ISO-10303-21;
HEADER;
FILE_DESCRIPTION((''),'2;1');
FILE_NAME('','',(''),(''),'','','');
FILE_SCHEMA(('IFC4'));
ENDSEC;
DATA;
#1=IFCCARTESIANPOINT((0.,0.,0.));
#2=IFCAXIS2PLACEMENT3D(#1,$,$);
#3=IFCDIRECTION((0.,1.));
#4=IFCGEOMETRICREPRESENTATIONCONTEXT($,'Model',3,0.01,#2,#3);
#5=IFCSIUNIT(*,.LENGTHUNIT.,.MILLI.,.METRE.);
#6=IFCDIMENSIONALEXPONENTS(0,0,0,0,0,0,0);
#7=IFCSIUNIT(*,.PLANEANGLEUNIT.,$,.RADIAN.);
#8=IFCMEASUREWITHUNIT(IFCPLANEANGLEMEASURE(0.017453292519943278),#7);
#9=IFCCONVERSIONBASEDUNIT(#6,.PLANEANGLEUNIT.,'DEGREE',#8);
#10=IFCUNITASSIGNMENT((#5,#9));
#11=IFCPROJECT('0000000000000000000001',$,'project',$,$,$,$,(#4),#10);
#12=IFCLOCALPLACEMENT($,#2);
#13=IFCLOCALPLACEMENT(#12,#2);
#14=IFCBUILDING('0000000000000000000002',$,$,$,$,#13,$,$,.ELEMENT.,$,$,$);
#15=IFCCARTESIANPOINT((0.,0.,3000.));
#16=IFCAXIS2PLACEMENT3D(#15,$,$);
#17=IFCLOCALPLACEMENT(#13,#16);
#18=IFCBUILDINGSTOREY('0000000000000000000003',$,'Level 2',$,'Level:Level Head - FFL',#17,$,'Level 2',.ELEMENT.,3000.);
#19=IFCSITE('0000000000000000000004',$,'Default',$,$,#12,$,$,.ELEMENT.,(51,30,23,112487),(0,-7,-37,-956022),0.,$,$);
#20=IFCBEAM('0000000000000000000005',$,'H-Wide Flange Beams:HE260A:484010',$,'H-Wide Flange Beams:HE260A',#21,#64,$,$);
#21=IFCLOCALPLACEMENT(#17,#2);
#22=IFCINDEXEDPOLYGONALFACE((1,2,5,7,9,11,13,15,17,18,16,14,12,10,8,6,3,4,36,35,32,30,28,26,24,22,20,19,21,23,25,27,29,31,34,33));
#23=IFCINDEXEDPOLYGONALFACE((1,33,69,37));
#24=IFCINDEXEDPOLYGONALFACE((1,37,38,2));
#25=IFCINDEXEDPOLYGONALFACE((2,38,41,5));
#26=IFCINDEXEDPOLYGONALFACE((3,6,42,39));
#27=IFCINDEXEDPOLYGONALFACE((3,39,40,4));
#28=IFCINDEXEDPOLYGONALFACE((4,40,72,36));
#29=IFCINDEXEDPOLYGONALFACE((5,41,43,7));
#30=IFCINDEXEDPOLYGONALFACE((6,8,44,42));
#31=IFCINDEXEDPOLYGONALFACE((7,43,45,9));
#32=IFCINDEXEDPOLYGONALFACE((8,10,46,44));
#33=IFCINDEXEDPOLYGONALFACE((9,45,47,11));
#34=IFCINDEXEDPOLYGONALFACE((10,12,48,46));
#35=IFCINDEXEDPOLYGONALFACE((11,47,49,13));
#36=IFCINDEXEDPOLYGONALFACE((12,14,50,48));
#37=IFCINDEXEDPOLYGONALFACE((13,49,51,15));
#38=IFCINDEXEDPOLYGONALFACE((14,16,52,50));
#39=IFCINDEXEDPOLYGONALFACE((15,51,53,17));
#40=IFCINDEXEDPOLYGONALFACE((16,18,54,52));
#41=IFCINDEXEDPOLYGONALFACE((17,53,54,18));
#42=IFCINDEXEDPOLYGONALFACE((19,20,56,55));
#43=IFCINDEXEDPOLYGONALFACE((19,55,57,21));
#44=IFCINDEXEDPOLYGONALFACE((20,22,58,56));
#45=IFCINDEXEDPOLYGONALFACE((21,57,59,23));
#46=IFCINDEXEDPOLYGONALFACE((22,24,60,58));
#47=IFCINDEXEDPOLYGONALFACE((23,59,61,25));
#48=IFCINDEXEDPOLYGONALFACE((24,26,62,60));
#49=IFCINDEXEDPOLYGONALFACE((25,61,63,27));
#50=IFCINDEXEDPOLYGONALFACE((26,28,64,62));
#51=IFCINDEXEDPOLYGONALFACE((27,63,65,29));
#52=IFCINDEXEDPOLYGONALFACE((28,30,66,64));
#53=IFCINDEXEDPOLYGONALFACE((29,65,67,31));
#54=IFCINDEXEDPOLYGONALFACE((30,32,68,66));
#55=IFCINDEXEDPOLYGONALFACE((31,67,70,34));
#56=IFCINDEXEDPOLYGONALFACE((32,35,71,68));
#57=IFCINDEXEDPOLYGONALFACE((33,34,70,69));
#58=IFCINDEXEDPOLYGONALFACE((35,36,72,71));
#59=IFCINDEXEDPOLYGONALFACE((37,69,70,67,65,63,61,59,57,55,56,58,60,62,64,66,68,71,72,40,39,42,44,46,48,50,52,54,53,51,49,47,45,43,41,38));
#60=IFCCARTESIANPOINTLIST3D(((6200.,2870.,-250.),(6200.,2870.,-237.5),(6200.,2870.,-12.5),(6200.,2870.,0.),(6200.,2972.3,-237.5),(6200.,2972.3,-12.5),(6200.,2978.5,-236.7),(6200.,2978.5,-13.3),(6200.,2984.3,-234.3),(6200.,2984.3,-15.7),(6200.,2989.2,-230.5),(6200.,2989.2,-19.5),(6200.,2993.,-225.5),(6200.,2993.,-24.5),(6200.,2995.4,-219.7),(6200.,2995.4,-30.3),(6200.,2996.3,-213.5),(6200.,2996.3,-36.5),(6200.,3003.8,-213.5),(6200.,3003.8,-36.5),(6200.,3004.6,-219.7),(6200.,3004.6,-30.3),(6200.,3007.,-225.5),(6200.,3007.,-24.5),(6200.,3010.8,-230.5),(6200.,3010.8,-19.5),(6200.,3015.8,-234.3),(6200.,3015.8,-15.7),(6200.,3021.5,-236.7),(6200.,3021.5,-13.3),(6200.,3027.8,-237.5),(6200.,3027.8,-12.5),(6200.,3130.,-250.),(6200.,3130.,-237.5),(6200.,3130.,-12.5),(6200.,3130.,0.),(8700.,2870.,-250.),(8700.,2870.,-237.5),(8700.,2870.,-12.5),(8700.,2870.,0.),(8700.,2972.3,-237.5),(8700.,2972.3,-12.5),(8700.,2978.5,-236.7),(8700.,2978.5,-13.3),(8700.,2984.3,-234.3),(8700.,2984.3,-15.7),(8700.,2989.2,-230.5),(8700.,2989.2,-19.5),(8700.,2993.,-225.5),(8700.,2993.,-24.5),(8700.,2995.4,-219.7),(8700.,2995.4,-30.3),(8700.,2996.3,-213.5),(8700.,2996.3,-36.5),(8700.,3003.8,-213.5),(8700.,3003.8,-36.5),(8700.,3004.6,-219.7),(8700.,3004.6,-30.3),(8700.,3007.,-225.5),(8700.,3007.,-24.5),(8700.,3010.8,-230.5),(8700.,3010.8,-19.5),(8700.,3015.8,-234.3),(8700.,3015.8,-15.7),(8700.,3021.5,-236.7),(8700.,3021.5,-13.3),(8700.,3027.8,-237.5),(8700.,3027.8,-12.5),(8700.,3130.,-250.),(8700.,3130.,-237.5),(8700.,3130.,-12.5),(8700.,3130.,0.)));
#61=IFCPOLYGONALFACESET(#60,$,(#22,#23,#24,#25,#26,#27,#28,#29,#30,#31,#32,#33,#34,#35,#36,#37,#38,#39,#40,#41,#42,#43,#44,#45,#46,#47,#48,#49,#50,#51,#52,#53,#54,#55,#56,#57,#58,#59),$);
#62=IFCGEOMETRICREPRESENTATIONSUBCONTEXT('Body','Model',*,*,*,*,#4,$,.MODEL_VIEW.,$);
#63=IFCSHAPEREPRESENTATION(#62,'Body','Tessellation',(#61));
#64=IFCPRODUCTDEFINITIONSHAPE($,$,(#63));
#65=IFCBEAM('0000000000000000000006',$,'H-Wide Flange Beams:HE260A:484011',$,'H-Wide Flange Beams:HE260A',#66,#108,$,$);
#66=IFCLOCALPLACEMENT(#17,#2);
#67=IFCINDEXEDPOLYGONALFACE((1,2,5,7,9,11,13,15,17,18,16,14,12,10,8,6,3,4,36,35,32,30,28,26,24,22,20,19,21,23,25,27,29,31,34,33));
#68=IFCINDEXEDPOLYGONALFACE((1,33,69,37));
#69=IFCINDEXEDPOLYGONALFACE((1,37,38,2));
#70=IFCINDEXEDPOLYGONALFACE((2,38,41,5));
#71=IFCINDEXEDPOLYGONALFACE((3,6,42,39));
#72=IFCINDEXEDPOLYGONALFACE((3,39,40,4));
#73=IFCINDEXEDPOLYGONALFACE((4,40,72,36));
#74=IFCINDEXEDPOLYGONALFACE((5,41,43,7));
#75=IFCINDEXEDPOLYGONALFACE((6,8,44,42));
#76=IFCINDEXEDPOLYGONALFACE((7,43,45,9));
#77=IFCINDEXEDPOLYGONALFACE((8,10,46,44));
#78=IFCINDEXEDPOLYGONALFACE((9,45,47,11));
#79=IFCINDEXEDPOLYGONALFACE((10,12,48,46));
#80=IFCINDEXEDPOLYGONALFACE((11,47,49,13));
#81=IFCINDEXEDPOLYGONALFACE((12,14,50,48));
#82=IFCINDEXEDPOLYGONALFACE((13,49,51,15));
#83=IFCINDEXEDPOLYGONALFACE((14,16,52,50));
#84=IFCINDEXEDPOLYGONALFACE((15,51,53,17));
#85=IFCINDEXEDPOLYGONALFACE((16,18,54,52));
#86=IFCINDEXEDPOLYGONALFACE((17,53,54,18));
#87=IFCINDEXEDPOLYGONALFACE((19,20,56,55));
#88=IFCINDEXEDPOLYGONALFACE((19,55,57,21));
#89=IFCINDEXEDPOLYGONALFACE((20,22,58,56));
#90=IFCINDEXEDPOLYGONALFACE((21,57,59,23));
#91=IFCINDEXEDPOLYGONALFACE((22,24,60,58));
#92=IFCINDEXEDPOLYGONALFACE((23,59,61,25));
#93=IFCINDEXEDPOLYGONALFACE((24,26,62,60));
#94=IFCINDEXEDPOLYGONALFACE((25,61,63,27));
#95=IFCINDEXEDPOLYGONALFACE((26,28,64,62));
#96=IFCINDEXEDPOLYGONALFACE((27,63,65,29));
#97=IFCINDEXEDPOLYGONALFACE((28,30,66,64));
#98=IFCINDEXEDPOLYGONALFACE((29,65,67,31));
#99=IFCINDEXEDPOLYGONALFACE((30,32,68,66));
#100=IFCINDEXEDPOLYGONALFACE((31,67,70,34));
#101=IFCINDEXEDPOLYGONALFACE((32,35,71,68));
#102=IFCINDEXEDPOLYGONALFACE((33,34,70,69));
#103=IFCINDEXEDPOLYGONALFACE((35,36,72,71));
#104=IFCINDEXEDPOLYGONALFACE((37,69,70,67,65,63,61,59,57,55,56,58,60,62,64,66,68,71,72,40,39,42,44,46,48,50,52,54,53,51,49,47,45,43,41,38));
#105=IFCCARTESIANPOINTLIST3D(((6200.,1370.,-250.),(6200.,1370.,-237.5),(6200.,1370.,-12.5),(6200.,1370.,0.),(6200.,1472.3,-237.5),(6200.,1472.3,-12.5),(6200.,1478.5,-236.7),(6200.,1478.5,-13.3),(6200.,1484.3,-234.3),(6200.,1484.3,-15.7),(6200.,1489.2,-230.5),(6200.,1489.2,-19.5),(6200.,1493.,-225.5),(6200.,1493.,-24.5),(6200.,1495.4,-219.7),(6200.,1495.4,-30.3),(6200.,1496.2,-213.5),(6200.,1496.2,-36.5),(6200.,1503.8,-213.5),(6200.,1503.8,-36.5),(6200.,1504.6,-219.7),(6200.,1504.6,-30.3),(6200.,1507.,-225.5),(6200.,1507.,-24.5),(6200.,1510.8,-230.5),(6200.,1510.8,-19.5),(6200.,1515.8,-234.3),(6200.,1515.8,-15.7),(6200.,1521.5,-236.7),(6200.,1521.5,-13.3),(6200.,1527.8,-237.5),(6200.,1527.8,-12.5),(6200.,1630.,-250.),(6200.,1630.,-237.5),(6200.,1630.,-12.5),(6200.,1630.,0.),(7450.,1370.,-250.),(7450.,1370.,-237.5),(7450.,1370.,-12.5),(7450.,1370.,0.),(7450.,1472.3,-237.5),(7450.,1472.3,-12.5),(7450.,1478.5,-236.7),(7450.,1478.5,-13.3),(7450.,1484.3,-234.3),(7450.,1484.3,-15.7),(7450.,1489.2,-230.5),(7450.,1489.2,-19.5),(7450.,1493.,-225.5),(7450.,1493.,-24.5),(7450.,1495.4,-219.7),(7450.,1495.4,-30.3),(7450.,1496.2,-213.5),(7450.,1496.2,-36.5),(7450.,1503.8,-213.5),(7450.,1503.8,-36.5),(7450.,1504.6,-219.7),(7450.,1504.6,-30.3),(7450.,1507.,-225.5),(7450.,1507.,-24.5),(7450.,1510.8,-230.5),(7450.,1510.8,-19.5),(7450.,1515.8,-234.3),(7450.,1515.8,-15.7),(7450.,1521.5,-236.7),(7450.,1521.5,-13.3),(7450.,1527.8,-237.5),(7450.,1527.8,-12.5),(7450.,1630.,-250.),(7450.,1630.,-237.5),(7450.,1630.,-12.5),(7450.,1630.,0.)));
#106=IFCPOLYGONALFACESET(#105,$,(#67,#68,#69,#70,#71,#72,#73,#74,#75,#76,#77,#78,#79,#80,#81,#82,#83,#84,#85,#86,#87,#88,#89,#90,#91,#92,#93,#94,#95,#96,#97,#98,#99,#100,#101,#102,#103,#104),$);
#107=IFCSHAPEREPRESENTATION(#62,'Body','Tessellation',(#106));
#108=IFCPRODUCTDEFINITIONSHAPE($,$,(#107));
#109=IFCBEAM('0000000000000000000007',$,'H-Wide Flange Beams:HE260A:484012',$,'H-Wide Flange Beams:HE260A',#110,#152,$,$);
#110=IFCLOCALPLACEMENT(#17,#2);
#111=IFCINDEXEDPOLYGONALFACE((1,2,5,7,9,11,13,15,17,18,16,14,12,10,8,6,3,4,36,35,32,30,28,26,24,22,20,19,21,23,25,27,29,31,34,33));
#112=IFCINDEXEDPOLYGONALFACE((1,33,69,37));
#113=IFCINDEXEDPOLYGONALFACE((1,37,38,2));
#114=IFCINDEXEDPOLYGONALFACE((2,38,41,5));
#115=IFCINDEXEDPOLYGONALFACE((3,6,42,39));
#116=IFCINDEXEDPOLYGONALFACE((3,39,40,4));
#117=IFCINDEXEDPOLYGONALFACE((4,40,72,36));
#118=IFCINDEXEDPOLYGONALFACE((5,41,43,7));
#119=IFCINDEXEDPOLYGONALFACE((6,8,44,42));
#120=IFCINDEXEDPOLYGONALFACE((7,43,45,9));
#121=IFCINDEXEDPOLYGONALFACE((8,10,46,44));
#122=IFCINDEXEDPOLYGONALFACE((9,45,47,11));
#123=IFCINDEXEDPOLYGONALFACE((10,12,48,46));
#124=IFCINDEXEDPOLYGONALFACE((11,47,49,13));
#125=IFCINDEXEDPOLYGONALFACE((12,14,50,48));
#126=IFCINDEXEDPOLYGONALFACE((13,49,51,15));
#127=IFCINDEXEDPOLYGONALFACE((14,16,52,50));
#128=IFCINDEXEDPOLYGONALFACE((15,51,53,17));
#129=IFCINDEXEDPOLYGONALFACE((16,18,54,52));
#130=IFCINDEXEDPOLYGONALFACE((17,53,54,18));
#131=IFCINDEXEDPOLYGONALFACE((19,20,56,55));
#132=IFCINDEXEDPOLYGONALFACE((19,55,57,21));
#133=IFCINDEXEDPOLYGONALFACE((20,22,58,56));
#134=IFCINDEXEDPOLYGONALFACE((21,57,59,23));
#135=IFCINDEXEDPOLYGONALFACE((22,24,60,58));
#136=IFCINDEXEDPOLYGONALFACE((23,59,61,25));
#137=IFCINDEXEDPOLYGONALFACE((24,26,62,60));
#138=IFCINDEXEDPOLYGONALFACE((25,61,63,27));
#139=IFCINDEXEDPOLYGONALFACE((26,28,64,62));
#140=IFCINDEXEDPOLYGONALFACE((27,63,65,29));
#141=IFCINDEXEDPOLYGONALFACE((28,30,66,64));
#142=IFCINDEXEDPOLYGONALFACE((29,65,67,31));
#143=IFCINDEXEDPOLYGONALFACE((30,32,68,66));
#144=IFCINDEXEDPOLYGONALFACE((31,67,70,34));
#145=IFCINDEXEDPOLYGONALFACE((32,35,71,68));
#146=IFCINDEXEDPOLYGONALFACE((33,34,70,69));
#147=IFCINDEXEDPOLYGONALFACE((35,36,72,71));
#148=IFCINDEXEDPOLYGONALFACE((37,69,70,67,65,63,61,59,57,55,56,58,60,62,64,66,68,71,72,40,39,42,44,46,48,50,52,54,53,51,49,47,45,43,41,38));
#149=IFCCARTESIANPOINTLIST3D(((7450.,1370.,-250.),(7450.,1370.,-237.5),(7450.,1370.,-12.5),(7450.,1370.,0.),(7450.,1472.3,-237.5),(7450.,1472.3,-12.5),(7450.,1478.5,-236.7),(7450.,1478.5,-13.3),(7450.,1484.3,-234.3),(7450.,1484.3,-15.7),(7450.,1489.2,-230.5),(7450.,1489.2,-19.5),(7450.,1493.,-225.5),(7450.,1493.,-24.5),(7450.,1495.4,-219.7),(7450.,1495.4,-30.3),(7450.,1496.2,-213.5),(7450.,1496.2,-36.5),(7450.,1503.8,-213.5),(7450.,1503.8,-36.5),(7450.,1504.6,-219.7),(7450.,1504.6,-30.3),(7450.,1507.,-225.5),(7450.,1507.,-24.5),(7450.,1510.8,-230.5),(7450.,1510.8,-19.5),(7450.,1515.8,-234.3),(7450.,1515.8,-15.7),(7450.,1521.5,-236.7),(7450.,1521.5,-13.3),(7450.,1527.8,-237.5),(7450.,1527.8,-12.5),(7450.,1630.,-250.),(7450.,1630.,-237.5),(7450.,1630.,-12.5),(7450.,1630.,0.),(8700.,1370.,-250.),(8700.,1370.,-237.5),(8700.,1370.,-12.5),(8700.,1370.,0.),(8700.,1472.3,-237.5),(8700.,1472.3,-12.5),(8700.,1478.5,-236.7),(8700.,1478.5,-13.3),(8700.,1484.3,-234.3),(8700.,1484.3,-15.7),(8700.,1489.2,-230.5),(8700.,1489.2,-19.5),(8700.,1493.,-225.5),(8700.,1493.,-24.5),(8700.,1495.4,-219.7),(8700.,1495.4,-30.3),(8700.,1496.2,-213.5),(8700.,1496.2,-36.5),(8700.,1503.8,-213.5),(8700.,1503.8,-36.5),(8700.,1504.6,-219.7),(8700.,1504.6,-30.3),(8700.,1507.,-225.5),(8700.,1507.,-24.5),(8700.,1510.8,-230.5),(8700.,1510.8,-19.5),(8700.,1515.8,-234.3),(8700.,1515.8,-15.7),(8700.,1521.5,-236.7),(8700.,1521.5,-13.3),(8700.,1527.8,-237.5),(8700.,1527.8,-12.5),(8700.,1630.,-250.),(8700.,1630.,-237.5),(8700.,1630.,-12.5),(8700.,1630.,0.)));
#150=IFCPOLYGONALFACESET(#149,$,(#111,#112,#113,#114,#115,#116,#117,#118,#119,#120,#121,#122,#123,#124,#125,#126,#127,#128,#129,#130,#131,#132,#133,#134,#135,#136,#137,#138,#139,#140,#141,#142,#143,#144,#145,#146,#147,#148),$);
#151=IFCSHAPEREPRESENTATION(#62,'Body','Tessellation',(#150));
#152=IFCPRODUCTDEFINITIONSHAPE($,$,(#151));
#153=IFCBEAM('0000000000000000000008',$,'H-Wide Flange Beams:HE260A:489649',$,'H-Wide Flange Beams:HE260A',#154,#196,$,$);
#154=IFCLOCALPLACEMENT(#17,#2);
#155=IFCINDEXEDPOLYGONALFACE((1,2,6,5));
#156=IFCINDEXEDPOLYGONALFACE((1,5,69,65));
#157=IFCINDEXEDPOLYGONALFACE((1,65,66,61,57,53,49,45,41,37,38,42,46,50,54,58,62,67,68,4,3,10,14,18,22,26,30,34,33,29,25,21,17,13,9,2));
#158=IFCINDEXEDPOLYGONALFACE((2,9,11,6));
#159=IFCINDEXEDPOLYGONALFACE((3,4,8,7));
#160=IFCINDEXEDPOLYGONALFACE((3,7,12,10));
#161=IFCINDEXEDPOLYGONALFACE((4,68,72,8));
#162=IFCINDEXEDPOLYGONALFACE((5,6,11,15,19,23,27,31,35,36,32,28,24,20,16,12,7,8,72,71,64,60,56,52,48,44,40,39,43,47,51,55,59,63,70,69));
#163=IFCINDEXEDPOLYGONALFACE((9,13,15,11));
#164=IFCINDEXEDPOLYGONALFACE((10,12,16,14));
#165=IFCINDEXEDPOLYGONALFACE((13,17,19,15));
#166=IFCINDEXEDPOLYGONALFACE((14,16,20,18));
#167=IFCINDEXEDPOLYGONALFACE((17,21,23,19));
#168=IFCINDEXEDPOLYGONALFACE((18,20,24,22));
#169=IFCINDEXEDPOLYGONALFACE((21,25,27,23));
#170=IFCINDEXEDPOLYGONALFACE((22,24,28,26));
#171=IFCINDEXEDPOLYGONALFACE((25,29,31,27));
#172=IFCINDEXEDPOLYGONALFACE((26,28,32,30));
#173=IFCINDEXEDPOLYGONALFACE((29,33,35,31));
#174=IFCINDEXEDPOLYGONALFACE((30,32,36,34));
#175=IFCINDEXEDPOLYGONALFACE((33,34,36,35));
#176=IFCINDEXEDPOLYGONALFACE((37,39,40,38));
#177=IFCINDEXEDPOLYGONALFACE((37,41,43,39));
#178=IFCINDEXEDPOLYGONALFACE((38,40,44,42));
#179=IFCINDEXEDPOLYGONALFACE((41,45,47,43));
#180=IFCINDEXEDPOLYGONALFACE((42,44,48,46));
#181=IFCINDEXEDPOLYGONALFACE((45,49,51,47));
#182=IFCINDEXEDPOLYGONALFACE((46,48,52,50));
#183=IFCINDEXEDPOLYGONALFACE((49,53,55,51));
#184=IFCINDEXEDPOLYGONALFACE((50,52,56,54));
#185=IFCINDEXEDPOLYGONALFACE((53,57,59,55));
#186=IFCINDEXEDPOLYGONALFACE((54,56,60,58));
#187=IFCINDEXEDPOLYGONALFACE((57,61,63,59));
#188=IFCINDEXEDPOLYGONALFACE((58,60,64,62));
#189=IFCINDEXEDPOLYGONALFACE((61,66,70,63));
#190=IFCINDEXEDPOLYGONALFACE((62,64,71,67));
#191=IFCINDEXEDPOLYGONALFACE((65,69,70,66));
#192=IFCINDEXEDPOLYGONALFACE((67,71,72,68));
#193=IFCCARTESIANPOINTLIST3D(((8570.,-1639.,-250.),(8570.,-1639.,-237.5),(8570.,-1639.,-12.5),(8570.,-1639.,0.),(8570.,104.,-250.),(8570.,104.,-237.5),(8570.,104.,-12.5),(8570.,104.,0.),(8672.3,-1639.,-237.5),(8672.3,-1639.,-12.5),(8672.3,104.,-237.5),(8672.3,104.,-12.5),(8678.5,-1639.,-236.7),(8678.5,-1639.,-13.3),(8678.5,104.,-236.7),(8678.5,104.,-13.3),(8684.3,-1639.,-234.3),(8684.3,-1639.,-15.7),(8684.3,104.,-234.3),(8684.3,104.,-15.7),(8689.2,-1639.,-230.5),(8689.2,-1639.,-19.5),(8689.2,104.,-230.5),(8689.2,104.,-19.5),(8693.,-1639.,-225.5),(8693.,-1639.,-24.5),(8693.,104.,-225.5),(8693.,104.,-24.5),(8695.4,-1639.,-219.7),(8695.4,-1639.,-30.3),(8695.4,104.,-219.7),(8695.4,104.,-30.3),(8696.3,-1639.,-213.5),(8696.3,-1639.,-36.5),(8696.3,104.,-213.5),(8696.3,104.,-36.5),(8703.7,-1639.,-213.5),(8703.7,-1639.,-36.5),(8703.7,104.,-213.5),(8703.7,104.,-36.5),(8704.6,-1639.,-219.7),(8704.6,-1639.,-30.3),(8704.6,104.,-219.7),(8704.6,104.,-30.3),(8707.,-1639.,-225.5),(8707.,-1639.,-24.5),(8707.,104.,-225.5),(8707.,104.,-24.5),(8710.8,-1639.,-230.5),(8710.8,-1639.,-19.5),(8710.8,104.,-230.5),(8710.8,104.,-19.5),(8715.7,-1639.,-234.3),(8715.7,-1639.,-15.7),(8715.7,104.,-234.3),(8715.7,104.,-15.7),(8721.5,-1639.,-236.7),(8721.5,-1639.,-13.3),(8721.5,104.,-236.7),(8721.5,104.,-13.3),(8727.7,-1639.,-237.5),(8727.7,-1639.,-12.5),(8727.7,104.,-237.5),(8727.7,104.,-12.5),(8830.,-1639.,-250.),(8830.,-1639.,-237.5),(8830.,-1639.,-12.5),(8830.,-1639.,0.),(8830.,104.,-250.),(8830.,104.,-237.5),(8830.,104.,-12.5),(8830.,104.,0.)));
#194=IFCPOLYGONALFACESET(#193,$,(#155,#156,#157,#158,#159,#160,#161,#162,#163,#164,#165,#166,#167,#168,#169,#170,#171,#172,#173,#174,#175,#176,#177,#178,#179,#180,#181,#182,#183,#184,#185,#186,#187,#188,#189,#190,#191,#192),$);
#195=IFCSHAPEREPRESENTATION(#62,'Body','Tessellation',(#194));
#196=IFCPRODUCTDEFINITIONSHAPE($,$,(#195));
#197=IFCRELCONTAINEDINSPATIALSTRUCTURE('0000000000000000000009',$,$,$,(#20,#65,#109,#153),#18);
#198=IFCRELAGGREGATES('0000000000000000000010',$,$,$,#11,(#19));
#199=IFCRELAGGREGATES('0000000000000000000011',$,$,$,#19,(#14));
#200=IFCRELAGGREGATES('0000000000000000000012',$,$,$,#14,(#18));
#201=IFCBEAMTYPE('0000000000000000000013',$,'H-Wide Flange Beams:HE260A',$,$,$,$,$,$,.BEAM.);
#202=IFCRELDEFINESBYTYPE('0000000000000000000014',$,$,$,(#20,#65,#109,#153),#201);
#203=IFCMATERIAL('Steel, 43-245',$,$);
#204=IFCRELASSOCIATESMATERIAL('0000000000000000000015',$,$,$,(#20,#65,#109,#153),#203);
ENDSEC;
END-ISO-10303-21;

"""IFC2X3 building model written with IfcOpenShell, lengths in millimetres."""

from ifc_helpers import new_model, entity, si_unit, converted_unit, direction, frame, frame_2d, origin, place, context, subcontext, project, spatial, i_section, extrude, material, type_object, element, save


model = new_model("IFC2X3")

# Units and contexts
model_context = context("Model", 3, precision=0.01, world=origin(), true_north=direction((0.0, 1.0)))
body_context = subcontext(model_context, "Body", "Model", "MODEL_VIEW")
ifc_project = project(units=[si_unit("LENGTHUNIT", "METRE", prefix="MILLI"), converted_unit("PLANEANGLEUNIT", "DEGREE", entity("IfcPlaneAngleMeasure", 0.017453292519943278), si_unit("PLANEANGLEUNIT", "RADIAN"), dimensions=[0, 0, 0, 0, 0, 0, 0])], contexts=[model_context])

# Site, building, storey
site_placement = place(None, origin())
site = spatial("IfcSite", under=ifc_project, at=site_placement, Name="Default", CompositionType="ELEMENT", RefLatitude=(51, 30, 23, 112487), RefLongitude=(0, -7, -37, -956022), RefElevation=0.0)
building_placement = place(site_placement, origin())
building = spatial("IfcBuilding", under=site, at=building_placement, CompositionType="ELEMENT")
storey_placement = place(building_placement, frame((0.0, 0.0, 3000.0)))
storey = spatial("IfcBuildingStorey", under=building, at=storey_placement, Name="Level 2", ObjectType="Level:Level Head - FFL", LongName="Level 2", CompositionType="ELEMENT", Elevation=3000.0)

# Beams
ifc_material = material(Name="Steel, 43-245")
beam_type_1 = type_object("IfcBeamType", Name="H-Wide Flange Beams:HE260A", PredefinedType="BEAM")
beam_1_placement = place(storey_placement, frame((8700.0, 3000.0, 0.0), z_axis=(0.0, 0.0, 1.0), x_axis=(-1.0, 0.0, 0.0)))
element("IfcBeam", 1, at=beam_1_placement, inside=storey, type_object=beam_type_1, material=ifc_material, Name="H-Wide Flange Beams:HE260A:484010", ObjectType="H-Wide Flange Beams:HE260A", context=body_context, shape_type="SweptSolid", body=[
    extrude(i_section(OverallWidth=260.0, OverallDepth=250.0, WebThickness=7.5, FlangeThickness=12.5, FilletRadius=24.0, at=frame_2d((0.0, 0.0), x_axis=(0.0, 1.0))), frame((0.0, 0.0, -125.0), z_axis=(1.0, 0.0, 0.0), x_axis=(0.0, 0.0, -1.0)), (0.0, 0.0, 1.0), 2500.0),
])
beam_2_placement = place(storey_placement, frame((6200.0, 1500.0, 0.0)))
element("IfcBeam", 2, at=beam_2_placement, inside=storey, type_object=beam_type_1, material=ifc_material, Name="H-Wide Flange Beams:HE260A:484011", ObjectType="H-Wide Flange Beams:HE260A", context=body_context, shape_type="SweptSolid", body=[
    extrude(i_section(OverallWidth=260.0, OverallDepth=250.0, WebThickness=7.5, FlangeThickness=12.5, FilletRadius=24.0, at=frame_2d((0.0, 0.0), x_axis=(0.0, 1.0))), frame((0.0, 0.0, -125.0), z_axis=(1.0, 0.0, 0.0), x_axis=(0.0, 0.0, -1.0)), (0.0, 0.0, 1.0), 1250.0),
])
beam_3_placement = place(storey_placement, frame((8700.0, 1500.0, 0.0), z_axis=(0.0, 0.0, 1.0), x_axis=(-1.0, 0.0, 0.0)))
element("IfcBeam", 3, at=beam_3_placement, inside=storey, type_object=beam_type_1, material=ifc_material, Name="H-Wide Flange Beams:HE260A:484012", ObjectType="H-Wide Flange Beams:HE260A", context=body_context, shape_type="SweptSolid", body=[
    extrude(i_section(OverallWidth=260.0, OverallDepth=250.0, WebThickness=7.5, FlangeThickness=12.5, FilletRadius=24.0, at=frame_2d((0.0, 0.0), x_axis=(0.0, 1.0))), frame((0.0, 0.0, -125.0), z_axis=(1.0, 0.0, 0.0), x_axis=(0.0, 0.0, -1.0)), (0.0, 0.0, 1.0), 1250.0),
])
beam_4_placement = place(storey_placement, frame((8700.0, -1500.0, 0.0), z_axis=(0.0, 0.0, 1.0), x_axis=(0.0, 1.0, 0.0)))
element("IfcBeam", 4, at=beam_4_placement, inside=storey, type_object=beam_type_1, material=ifc_material, Name="H-Wide Flange Beams:HE260A:489649", ObjectType="H-Wide Flange Beams:HE260A", context=body_context, shape_type="SweptSolid", body=[
    extrude(i_section(OverallWidth=260.0, OverallDepth=250.0, WebThickness=7.5, FlangeThickness=12.5, FilletRadius=24.0, at=frame_2d((0.0, 0.0), x_axis=(0.0, 1.0))), frame((-139.0, 0.0, -125.0), z_axis=(1.0, 0.0, 0.0), x_axis=(0.0, 0.0, -1.0)), (0.0, 0.0, 1.0), 1743.0),
])

save(model, "model.ifc")
